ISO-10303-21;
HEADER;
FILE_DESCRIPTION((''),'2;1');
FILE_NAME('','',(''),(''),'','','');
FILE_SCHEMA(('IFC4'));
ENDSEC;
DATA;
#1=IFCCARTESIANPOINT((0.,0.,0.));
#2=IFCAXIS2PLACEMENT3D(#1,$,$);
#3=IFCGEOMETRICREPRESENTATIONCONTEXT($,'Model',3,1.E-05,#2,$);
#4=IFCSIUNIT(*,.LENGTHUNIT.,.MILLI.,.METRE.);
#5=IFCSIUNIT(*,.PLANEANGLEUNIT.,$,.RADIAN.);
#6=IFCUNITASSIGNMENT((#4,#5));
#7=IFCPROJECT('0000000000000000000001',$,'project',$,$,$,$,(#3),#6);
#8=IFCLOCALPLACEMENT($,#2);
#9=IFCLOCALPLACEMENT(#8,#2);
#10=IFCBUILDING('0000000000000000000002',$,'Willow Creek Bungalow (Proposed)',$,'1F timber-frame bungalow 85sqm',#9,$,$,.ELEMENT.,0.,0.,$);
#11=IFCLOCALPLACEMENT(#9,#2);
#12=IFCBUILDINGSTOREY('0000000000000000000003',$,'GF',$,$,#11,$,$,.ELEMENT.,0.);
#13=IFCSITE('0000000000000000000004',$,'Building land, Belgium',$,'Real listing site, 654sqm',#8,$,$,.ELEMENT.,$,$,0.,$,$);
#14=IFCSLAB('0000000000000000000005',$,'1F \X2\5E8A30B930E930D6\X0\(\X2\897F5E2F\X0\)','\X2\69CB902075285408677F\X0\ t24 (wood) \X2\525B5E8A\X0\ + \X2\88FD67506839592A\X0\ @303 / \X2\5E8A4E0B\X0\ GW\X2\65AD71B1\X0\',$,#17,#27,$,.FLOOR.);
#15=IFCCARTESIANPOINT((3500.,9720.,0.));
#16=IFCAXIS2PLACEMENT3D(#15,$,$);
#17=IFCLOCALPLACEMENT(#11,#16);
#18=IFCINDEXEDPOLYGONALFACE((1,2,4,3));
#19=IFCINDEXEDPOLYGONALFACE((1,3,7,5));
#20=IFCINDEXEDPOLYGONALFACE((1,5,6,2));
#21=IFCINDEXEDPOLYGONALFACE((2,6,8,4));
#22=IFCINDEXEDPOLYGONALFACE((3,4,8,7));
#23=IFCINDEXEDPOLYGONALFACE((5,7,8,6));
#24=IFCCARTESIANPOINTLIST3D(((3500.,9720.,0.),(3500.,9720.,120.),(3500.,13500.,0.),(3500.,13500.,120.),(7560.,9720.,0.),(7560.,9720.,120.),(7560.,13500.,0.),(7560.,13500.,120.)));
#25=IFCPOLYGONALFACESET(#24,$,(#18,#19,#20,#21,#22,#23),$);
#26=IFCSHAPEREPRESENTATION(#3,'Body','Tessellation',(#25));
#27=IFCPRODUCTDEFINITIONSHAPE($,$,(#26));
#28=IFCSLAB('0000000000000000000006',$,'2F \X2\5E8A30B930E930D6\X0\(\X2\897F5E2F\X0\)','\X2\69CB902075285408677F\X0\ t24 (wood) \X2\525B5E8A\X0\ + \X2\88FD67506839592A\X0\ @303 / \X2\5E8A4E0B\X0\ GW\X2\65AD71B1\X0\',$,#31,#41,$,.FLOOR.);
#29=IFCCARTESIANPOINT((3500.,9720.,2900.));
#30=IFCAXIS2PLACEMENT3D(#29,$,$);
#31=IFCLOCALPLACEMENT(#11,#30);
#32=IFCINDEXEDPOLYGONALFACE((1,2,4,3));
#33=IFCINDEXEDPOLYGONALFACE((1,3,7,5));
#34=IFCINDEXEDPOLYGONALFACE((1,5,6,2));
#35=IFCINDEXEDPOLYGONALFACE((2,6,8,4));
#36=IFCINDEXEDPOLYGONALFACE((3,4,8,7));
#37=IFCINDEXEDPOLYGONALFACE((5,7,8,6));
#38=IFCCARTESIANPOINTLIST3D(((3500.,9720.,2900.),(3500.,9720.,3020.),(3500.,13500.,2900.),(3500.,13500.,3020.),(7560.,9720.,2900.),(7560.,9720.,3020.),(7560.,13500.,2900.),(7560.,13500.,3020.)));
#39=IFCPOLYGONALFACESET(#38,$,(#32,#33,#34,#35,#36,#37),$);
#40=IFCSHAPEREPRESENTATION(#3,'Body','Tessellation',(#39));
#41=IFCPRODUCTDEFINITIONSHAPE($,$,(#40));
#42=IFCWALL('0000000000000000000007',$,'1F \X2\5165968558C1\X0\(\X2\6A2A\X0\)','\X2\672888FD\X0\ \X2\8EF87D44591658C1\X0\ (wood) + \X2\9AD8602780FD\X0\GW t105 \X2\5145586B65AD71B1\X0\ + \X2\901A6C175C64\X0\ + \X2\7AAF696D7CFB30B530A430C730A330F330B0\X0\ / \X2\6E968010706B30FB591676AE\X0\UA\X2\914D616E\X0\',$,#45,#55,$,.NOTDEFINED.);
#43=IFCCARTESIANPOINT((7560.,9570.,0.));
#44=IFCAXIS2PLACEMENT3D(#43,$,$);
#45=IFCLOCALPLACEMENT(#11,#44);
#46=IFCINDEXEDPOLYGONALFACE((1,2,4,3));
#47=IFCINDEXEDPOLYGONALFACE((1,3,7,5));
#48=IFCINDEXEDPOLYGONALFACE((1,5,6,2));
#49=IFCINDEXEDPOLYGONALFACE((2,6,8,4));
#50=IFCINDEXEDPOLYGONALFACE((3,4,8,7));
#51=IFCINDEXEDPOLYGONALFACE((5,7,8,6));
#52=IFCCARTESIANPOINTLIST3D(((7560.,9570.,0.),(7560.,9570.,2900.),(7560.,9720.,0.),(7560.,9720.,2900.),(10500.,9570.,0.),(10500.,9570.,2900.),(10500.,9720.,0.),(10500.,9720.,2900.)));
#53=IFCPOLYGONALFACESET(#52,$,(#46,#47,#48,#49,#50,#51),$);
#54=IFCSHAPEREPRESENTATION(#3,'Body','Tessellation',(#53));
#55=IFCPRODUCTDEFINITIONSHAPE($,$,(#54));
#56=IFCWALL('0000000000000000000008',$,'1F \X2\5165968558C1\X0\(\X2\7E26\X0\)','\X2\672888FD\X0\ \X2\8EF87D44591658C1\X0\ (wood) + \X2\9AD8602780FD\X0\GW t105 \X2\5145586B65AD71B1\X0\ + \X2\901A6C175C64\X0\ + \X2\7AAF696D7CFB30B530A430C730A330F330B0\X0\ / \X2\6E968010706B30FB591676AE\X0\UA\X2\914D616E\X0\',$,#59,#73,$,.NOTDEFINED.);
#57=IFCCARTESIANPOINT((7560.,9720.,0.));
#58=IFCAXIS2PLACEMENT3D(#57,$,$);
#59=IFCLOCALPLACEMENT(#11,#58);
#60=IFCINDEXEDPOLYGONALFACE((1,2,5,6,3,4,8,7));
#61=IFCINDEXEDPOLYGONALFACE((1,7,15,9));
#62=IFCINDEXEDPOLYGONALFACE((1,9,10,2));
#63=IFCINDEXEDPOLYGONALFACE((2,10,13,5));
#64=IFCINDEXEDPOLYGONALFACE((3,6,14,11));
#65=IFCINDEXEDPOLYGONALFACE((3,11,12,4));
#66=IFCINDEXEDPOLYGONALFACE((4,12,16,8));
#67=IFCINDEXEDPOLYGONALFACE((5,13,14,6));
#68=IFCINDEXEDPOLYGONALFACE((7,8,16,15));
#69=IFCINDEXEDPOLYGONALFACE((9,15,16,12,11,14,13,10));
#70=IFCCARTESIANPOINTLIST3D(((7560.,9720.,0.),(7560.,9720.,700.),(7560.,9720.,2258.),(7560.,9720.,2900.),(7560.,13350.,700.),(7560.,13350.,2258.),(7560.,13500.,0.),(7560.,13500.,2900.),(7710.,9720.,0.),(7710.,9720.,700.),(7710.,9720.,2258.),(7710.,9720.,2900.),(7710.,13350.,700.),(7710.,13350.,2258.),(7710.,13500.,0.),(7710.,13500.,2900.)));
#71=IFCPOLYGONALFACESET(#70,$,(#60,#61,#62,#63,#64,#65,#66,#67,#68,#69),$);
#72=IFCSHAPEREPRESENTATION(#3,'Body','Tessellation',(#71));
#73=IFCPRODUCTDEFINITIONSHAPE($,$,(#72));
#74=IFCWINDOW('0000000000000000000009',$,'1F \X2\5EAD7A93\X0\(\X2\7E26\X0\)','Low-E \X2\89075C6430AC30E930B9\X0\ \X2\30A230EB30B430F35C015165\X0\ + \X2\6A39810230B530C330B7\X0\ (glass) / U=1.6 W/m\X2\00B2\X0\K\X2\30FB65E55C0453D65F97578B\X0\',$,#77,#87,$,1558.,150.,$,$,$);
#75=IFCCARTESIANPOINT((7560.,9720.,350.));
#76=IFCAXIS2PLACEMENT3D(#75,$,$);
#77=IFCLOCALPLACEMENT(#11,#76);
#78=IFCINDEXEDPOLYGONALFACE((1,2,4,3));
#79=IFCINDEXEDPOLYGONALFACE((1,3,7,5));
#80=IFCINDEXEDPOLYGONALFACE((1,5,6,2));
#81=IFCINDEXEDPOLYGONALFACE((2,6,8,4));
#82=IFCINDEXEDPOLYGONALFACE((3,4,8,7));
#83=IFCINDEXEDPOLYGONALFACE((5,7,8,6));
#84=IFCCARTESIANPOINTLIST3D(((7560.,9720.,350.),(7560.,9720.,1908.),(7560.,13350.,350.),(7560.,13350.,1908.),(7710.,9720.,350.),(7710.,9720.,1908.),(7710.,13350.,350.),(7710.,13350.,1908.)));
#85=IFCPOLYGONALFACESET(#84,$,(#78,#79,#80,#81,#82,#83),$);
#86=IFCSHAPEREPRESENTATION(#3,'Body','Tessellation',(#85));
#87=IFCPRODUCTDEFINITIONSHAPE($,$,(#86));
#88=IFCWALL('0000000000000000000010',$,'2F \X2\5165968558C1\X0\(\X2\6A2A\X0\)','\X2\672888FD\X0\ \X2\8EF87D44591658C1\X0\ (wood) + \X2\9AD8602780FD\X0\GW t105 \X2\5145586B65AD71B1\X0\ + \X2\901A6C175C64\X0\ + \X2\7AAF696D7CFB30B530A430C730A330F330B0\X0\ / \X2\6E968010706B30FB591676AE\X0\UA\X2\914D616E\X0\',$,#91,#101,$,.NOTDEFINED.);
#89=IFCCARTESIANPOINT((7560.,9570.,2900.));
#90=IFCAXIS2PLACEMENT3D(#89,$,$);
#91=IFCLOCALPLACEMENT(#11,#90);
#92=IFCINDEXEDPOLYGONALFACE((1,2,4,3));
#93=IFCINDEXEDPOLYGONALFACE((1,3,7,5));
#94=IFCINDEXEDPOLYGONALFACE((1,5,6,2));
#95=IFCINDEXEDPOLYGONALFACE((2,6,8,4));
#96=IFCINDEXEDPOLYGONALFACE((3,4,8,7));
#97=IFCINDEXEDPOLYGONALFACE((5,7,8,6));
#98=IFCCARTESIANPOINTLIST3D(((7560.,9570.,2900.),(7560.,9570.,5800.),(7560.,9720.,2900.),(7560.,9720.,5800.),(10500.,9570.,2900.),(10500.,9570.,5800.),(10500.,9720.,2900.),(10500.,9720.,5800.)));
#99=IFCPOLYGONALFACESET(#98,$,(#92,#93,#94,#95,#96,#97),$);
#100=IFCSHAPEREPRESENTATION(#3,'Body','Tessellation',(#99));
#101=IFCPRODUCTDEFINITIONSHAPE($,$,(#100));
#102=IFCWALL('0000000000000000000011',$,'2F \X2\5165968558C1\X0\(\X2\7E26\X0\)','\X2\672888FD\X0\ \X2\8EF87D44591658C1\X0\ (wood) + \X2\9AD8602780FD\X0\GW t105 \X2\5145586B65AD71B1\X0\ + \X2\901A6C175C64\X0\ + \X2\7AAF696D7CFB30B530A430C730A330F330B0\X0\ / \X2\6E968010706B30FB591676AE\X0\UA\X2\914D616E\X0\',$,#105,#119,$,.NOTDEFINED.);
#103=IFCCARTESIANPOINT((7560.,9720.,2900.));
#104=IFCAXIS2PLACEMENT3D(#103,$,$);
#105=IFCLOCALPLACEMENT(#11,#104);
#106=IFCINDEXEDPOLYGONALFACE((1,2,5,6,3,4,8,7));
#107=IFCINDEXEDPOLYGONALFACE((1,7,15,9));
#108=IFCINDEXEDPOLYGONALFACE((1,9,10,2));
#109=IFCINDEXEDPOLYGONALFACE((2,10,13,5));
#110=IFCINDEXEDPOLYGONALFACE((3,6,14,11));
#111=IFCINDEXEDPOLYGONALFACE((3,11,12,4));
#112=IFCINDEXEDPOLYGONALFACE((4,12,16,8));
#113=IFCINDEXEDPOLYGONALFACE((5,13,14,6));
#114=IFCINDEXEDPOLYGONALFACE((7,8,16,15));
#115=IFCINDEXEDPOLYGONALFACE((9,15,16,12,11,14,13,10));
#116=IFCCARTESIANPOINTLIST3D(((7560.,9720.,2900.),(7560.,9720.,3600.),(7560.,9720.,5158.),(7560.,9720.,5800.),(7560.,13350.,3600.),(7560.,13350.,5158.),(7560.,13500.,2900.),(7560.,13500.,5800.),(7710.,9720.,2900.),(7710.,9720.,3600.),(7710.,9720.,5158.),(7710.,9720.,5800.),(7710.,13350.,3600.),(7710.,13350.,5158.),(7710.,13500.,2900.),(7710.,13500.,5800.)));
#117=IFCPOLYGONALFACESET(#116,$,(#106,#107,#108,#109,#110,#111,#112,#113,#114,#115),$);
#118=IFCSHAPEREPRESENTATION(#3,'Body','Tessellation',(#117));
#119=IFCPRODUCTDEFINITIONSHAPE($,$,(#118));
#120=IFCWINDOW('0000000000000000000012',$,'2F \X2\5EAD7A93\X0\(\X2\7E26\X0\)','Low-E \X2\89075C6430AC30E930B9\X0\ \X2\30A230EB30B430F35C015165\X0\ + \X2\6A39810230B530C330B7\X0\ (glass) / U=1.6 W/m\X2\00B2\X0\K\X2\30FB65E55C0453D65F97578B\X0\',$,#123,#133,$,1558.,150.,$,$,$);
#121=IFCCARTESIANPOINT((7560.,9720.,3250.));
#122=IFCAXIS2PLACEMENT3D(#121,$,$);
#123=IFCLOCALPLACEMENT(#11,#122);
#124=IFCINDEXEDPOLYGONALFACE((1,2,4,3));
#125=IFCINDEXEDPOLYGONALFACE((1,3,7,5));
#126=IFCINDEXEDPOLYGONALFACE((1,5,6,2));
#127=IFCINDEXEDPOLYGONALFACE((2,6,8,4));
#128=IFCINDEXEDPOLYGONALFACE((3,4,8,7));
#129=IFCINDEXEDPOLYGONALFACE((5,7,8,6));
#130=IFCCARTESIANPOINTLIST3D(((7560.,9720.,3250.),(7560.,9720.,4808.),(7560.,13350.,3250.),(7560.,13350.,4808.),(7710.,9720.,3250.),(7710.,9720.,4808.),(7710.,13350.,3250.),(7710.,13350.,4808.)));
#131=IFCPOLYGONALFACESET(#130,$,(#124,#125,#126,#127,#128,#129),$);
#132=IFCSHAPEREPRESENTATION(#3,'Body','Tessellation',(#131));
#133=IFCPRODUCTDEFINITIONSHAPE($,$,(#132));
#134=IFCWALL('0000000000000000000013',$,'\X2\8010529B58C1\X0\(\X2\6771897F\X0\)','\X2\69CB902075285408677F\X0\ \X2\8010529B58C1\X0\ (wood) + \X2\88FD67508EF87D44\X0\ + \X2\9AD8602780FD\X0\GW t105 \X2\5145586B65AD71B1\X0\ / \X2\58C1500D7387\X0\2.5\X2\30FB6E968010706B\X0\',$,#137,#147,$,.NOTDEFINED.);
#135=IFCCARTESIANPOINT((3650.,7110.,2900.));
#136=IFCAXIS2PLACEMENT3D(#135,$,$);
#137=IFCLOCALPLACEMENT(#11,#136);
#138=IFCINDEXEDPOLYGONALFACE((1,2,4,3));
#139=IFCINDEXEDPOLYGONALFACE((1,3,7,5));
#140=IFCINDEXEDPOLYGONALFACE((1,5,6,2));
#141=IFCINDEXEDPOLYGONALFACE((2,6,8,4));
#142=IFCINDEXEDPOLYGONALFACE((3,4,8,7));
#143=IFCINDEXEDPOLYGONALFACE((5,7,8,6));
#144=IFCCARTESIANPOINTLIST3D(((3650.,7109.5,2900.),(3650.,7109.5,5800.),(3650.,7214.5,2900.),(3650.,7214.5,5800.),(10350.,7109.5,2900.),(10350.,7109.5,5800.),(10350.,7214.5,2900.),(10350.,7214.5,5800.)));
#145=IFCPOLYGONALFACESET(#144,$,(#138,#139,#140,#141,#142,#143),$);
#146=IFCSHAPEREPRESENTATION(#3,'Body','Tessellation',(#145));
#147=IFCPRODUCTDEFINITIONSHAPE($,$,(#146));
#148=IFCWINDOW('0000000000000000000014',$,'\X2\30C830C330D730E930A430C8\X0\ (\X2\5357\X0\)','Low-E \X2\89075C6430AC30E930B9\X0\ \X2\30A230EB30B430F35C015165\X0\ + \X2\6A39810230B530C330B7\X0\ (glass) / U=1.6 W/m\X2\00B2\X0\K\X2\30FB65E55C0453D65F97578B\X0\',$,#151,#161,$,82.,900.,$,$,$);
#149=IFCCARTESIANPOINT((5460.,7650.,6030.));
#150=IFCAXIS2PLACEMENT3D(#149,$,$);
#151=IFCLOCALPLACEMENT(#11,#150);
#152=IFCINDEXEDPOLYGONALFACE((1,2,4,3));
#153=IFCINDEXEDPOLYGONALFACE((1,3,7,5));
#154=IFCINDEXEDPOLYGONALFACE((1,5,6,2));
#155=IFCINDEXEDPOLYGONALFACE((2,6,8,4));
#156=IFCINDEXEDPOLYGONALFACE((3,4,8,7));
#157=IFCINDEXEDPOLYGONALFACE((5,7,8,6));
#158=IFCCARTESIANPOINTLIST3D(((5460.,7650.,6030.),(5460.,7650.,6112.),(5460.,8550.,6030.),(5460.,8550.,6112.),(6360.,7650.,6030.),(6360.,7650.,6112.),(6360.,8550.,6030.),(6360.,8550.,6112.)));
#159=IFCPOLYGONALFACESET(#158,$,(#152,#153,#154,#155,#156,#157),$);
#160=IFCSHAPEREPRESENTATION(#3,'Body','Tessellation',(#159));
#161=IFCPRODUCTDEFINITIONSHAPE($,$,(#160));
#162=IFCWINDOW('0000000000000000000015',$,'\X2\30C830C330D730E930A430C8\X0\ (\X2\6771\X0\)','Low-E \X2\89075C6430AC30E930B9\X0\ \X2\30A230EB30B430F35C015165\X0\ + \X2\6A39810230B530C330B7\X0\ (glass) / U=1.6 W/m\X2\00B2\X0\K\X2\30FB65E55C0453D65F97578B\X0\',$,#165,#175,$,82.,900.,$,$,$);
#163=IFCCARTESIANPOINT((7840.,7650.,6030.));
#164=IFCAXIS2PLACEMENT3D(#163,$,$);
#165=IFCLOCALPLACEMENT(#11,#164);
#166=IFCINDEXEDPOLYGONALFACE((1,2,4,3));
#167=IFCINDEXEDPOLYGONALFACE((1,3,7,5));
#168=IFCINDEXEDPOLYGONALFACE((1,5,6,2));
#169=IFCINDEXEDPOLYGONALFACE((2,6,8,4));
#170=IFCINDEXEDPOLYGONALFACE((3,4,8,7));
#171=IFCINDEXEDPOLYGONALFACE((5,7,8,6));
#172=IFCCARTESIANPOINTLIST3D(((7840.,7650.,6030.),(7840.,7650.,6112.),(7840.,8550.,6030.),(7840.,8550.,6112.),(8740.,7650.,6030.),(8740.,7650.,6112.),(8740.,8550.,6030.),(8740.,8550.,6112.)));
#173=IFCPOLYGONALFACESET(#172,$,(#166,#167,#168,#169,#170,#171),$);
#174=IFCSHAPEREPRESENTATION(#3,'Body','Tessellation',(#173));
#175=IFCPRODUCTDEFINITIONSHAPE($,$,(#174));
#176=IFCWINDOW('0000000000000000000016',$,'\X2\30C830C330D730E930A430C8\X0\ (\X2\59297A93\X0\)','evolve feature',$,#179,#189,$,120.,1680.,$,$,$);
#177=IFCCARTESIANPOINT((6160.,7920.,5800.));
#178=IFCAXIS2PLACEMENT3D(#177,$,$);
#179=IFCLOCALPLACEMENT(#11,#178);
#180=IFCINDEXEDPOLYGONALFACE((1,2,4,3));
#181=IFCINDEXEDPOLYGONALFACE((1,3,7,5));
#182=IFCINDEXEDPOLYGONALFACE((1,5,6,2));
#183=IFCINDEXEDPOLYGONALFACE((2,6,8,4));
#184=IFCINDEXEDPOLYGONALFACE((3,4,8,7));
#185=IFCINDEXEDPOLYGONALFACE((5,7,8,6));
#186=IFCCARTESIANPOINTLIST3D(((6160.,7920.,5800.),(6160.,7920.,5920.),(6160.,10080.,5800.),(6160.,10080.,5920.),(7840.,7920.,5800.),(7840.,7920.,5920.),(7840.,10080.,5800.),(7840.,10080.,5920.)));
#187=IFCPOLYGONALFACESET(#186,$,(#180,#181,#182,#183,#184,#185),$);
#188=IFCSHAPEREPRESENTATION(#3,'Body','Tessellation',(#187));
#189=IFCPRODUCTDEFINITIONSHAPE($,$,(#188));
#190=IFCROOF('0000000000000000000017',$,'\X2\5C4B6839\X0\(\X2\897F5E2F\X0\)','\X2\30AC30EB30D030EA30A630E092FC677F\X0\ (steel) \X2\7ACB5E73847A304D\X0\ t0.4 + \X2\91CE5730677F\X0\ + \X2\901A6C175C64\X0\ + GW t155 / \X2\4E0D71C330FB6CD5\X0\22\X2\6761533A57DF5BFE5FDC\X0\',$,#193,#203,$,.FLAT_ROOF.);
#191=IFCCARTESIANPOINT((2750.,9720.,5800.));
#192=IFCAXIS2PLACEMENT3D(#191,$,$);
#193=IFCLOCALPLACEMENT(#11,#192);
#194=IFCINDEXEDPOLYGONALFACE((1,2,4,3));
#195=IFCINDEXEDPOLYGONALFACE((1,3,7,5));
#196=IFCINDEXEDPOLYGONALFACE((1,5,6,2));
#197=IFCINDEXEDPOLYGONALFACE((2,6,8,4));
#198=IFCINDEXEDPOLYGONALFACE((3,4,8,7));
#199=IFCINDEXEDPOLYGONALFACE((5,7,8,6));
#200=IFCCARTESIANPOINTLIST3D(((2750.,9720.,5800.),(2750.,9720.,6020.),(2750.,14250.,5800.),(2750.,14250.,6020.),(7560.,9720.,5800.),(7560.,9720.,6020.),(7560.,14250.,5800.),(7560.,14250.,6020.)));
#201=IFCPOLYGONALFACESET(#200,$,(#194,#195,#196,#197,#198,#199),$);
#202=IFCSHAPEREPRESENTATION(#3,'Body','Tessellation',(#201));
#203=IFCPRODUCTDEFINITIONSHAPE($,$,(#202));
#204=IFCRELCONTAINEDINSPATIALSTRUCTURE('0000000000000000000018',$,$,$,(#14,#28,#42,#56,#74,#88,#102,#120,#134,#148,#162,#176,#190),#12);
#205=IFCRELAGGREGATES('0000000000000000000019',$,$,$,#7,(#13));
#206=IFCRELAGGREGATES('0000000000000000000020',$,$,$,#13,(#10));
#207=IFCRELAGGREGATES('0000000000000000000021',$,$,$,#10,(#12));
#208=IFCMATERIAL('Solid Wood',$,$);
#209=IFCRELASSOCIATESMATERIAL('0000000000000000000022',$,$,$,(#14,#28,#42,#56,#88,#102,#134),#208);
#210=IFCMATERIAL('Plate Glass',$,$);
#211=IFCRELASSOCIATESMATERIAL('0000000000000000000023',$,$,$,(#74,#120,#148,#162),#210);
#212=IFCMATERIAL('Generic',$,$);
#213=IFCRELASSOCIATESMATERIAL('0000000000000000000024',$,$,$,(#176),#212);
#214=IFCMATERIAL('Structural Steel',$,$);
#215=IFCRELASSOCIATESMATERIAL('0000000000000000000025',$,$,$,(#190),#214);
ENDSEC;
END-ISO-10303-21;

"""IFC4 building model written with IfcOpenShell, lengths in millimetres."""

from ifc_helpers import new_model, si_unit, frame, frame_2d, origin, place, context, project, spatial, rectangle, extrude, material, element, fill, save


model = new_model("IFC4")

# Units and contexts
model_context = context("Model", 3, precision=1e-05, world=origin())
ifc_project = project(units=[si_unit("LENGTHUNIT", "METRE", prefix="MILLI"), si_unit("PLANEANGLEUNIT", "RADIAN")], contexts=[model_context])

# Site, building, storey
site_placement = place(None, origin())
site = spatial("IfcSite", under=ifc_project, at=site_placement, Name="Building land, Belgium", ObjectType="Real listing site, 654sqm", CompositionType="ELEMENT", RefElevation=0.0)
building_placement = place(site_placement, origin())
building = spatial("IfcBuilding", under=site, at=building_placement, Name="Willow Creek Bungalow (Proposed)", ObjectType="1F timber-frame bungalow 85sqm", CompositionType="ELEMENT", ElevationOfRefHeight=0.0, ElevationOfTerrain=0.0)
storey_placement = place(building_placement, origin())
storey = spatial("IfcBuildingStorey", under=building, at=storey_placement, Name="GF", CompositionType="ELEMENT", Elevation=0.0)

# Slabs
ifc_material_1 = material(Name="Solid Wood")
slab_1_placement = place(storey_placement, frame((3500.0, 9720.0, 0.0)))
element("IfcSlab", 1, at=slab_1_placement, inside=storey, material=ifc_material_1, Name="1F 床スラブ(西帯)", Description="構造用合板 t24 (wood) 剛床 + 製材根太 @303 / 床下 GW断熱", PredefinedType="FLOOR", context=model_context, shape_type="SweptSolid", body=[
    extrude(rectangle(XDim=4060.0, YDim=3780.0, at=frame_2d((2030.0, 1890.0))), frame((3500.0, 9720.0, 0.0)), (0.0, 0.0, 1.0), 120.0),
])
slab_2_placement = place(storey_placement, frame((3500.0, 9720.0, 2900.0)))
element("IfcSlab", 2, at=slab_2_placement, inside=storey, material=ifc_material_1, Name="2F 床スラブ(西帯)", Description="構造用合板 t24 (wood) 剛床 + 製材根太 @303 / 床下 GW断熱", PredefinedType="FLOOR", context=model_context, shape_type="SweptSolid", body=[
    extrude(rectangle(XDim=4060.0, YDim=3780.0, at=frame_2d((2030.0, 1890.0))), frame((3500.0, 9720.0, 2900.0)), (0.0, 0.0, 1.0), 120.0),
])

# Wall
wall_1_placement = place(storey_placement, frame((7560.0, 9570.0, 0.0)))
element("IfcWall", 3, at=wall_1_placement, inside=storey, material=ifc_material_1, Name="1F 入隅壁(横)", Description="木製 軸組外壁 (wood) + 高性能GW t105 充填断熱 + 通気層 + 窯業系サイディング / 準耐火・外皮UA配慮", PredefinedType="NOTDEFINED", context=model_context, shape_type="SweptSolid", body=[
    extrude(rectangle(XDim=2940.0, YDim=150.0, at=frame_2d((1470.0, 75.0))), frame((7560.0, 9570.0, 0.0)), (0.0, 0.0, 1.0), 2900.0),
])

# Wall, opening, window
wall_2_placement = place(storey_placement, frame((7560.0, 9720.0, 0.0)))
wall_2 = element("IfcWall", 4, at=wall_2_placement, inside=storey, material=ifc_material_1, Name="1F 入隅壁(縦)", Description="木製 軸組外壁 (wood) + 高性能GW t105 充填断熱 + 通気層 + 窯業系サイディング / 準耐火・外皮UA配慮", PredefinedType="NOTDEFINED", context=model_context, shape_type="SweptSolid", body=[
    extrude(rectangle(XDim=150.0, YDim=3780.0, at=frame_2d((75.0, 1890.0))), frame((7560.0, 9720.0, 0.0)), (0.0, 0.0, 1.0), 2900.0),
])
opening_1_placement = place(storey_placement, frame((7560.0, 9720.0, 350.0)))
opening_1 = element("IfcOpeningElement", 5, at=opening_1_placement, cuts=wall_2, PredefinedType="NOTDEFINED", context=model_context, shape_type="SweptSolid", body=[
    extrude(rectangle(XDim=150.0, YDim=3630.0, at=frame_2d((75.0, 1815.0))), frame((7560.0, 9720.0, 350.0)), (0.0, 0.0, 1.0), 1558.0),
])
ifc_material_2 = material(Name="Plate Glass")
window_1_placement = place(storey_placement, frame((7560.0, 9720.0, 350.0)))
window_1 = element("IfcWindow", 6, at=window_1_placement, inside=storey, material=ifc_material_2, Name="1F 庭窓(縦)", Description="Low-E 複層ガラス アルゴン封入 + 樹脂サッシ (glass) / U=1.6 W/m²K・日射取得型", OverallHeight=1558.0, OverallWidth=150.0, context=model_context, shape_type="SweptSolid", body=[
    extrude(rectangle(XDim=150.0, YDim=3630.0, at=frame_2d((75.0, 1815.0))), frame((7560.0, 9720.0, 350.0)), (0.0, 0.0, 1.0), 1558.0),
])
fill(opening_1, window_1)

# Wall
wall_3_placement = place(storey_placement, frame((7560.0, 9570.0, 2900.0)))
element("IfcWall", 7, at=wall_3_placement, inside=storey, material=ifc_material_1, Name="2F 入隅壁(横)", Description="木製 軸組外壁 (wood) + 高性能GW t105 充填断熱 + 通気層 + 窯業系サイディング / 準耐火・外皮UA配慮", PredefinedType="NOTDEFINED", context=model_context, shape_type="SweptSolid", body=[
    extrude(rectangle(XDim=2940.0, YDim=150.0, at=frame_2d((1470.0, 75.0))), frame((7560.0, 9570.0, 2900.0)), (0.0, 0.0, 1.0), 2900.0),
])

# Wall, opening, window
wall_4_placement = place(storey_placement, frame((7560.0, 9720.0, 2900.0)))
wall_4 = element("IfcWall", 8, at=wall_4_placement, inside=storey, material=ifc_material_1, Name="2F 入隅壁(縦)", Description="木製 軸組外壁 (wood) + 高性能GW t105 充填断熱 + 通気層 + 窯業系サイディング / 準耐火・外皮UA配慮", PredefinedType="NOTDEFINED", context=model_context, shape_type="SweptSolid", body=[
    extrude(rectangle(XDim=150.0, YDim=3780.0, at=frame_2d((75.0, 1890.0))), frame((7560.0, 9720.0, 2900.0)), (0.0, 0.0, 1.0), 2900.0),
])
opening_2_placement = place(storey_placement, frame((7560.0, 9720.0, 3250.0)))
opening_2 = element("IfcOpeningElement", 9, at=opening_2_placement, cuts=wall_4, PredefinedType="NOTDEFINED", context=model_context, shape_type="SweptSolid", body=[
    extrude(rectangle(XDim=150.0, YDim=3630.0, at=frame_2d((75.0, 1815.0))), frame((7560.0, 9720.0, 3250.0)), (0.0, 0.0, 1.0), 1558.0),
])
window_2_placement = place(storey_placement, frame((7560.0, 9720.0, 3250.0)))
window_2 = element("IfcWindow", 10, at=window_2_placement, inside=storey, material=ifc_material_2, Name="2F 庭窓(縦)", Description="Low-E 複層ガラス アルゴン封入 + 樹脂サッシ (glass) / U=1.6 W/m²K・日射取得型", OverallHeight=1558.0, OverallWidth=150.0, context=model_context, shape_type="SweptSolid", body=[
    extrude(rectangle(XDim=150.0, YDim=3630.0, at=frame_2d((75.0, 1815.0))), frame((7560.0, 9720.0, 3250.0)), (0.0, 0.0, 1.0), 1558.0),
])
fill(opening_2, window_2)

# Wall
wall_5_placement = place(storey_placement, frame((3650.0, 7110.0, 2900.0)))
element("IfcWall", 11, at=wall_5_placement, inside=storey, material=ifc_material_1, Name="耐力壁(東西)", Description="構造用合板 耐力壁 (wood) + 製材軸組 + 高性能GW t105 充填断熱 / 壁倍率2.5・準耐火", PredefinedType="NOTDEFINED", context=model_context, shape_type="SweptSolid", body=[
    extrude(rectangle(XDim=6700.0, YDim=105.0, at=frame_2d((3350.0, 52.0))), frame((3650.0, 7110.0, 2900.0)), (0.0, 0.0, 1.0), 2900.0),
])

# Windows
window_3_placement = place(storey_placement, frame((5460.0, 7650.0, 6030.0)))
element("IfcWindow", 12, at=window_3_placement, inside=storey, material=ifc_material_2, Name="トップライト (南)", Description="Low-E 複層ガラス アルゴン封入 + 樹脂サッシ (glass) / U=1.6 W/m²K・日射取得型", OverallHeight=82.0, OverallWidth=900.0, context=model_context, shape_type="SweptSolid", body=[
    extrude(rectangle(XDim=900.0, YDim=900.0, at=frame_2d((450.0, 450.0))), frame((5460.0, 7650.0, 6030.0)), (0.0, 0.0, 1.0), 82.0),
])
window_4_placement = place(storey_placement, frame((7840.0, 7650.0, 6030.0)))
element("IfcWindow", 13, at=window_4_placement, inside=storey, material=ifc_material_2, Name="トップライト (東)", Description="Low-E 複層ガラス アルゴン封入 + 樹脂サッシ (glass) / U=1.6 W/m²K・日射取得型", OverallHeight=82.0, OverallWidth=900.0, context=model_context, shape_type="SweptSolid", body=[
    extrude(rectangle(XDim=900.0, YDim=900.0, at=frame_2d((450.0, 450.0))), frame((7840.0, 7650.0, 6030.0)), (0.0, 0.0, 1.0), 82.0),
])
ifc_material_3 = material(Name="Generic")
window_5_placement = place(storey_placement, frame((6160.0, 7920.0, 5800.0)))
element("IfcWindow", 14, at=window_5_placement, inside=storey, material=ifc_material_3, Name="トップライト (天窓)", Description="evolve feature", OverallHeight=120.0, OverallWidth=1680.0, context=model_context, shape_type="SweptSolid", body=[
    extrude(rectangle(XDim=1680.0, YDim=2160.0, at=frame_2d((840.0, 1080.0))), frame((6160.0, 7920.0, 5800.0)), (0.0, 0.0, 1.0), 120.0),
])

# Roof
ifc_material_4 = material(Name="Structural Steel")
for number, where, name in (
    (15, (2750.0, 9720.0, 5800.0), "屋根(西帯)"),
):
    element("IfcRoof", number, at=place(storey_placement, frame(where)), inside=storey, material=ifc_material_4, Name=name, Description="ガルバリウム鋼板 (steel) 立平葺き t0.4 + 野地板 + 通気層 + GW t155 / 不燃・法22条区域対応", PredefinedType="FLAT_ROOF", context=model_context, shape_type="SweptSolid", body=[
        extrude(rectangle(XDim=4810.0, YDim=4530.0, at=frame_2d((2405.0, 2265.0))), frame((2750.0, 9720.0, 5800.0)), (0.0, 0.0, 1.0), 220.0),
    ])

save(model, "model.ifc")
